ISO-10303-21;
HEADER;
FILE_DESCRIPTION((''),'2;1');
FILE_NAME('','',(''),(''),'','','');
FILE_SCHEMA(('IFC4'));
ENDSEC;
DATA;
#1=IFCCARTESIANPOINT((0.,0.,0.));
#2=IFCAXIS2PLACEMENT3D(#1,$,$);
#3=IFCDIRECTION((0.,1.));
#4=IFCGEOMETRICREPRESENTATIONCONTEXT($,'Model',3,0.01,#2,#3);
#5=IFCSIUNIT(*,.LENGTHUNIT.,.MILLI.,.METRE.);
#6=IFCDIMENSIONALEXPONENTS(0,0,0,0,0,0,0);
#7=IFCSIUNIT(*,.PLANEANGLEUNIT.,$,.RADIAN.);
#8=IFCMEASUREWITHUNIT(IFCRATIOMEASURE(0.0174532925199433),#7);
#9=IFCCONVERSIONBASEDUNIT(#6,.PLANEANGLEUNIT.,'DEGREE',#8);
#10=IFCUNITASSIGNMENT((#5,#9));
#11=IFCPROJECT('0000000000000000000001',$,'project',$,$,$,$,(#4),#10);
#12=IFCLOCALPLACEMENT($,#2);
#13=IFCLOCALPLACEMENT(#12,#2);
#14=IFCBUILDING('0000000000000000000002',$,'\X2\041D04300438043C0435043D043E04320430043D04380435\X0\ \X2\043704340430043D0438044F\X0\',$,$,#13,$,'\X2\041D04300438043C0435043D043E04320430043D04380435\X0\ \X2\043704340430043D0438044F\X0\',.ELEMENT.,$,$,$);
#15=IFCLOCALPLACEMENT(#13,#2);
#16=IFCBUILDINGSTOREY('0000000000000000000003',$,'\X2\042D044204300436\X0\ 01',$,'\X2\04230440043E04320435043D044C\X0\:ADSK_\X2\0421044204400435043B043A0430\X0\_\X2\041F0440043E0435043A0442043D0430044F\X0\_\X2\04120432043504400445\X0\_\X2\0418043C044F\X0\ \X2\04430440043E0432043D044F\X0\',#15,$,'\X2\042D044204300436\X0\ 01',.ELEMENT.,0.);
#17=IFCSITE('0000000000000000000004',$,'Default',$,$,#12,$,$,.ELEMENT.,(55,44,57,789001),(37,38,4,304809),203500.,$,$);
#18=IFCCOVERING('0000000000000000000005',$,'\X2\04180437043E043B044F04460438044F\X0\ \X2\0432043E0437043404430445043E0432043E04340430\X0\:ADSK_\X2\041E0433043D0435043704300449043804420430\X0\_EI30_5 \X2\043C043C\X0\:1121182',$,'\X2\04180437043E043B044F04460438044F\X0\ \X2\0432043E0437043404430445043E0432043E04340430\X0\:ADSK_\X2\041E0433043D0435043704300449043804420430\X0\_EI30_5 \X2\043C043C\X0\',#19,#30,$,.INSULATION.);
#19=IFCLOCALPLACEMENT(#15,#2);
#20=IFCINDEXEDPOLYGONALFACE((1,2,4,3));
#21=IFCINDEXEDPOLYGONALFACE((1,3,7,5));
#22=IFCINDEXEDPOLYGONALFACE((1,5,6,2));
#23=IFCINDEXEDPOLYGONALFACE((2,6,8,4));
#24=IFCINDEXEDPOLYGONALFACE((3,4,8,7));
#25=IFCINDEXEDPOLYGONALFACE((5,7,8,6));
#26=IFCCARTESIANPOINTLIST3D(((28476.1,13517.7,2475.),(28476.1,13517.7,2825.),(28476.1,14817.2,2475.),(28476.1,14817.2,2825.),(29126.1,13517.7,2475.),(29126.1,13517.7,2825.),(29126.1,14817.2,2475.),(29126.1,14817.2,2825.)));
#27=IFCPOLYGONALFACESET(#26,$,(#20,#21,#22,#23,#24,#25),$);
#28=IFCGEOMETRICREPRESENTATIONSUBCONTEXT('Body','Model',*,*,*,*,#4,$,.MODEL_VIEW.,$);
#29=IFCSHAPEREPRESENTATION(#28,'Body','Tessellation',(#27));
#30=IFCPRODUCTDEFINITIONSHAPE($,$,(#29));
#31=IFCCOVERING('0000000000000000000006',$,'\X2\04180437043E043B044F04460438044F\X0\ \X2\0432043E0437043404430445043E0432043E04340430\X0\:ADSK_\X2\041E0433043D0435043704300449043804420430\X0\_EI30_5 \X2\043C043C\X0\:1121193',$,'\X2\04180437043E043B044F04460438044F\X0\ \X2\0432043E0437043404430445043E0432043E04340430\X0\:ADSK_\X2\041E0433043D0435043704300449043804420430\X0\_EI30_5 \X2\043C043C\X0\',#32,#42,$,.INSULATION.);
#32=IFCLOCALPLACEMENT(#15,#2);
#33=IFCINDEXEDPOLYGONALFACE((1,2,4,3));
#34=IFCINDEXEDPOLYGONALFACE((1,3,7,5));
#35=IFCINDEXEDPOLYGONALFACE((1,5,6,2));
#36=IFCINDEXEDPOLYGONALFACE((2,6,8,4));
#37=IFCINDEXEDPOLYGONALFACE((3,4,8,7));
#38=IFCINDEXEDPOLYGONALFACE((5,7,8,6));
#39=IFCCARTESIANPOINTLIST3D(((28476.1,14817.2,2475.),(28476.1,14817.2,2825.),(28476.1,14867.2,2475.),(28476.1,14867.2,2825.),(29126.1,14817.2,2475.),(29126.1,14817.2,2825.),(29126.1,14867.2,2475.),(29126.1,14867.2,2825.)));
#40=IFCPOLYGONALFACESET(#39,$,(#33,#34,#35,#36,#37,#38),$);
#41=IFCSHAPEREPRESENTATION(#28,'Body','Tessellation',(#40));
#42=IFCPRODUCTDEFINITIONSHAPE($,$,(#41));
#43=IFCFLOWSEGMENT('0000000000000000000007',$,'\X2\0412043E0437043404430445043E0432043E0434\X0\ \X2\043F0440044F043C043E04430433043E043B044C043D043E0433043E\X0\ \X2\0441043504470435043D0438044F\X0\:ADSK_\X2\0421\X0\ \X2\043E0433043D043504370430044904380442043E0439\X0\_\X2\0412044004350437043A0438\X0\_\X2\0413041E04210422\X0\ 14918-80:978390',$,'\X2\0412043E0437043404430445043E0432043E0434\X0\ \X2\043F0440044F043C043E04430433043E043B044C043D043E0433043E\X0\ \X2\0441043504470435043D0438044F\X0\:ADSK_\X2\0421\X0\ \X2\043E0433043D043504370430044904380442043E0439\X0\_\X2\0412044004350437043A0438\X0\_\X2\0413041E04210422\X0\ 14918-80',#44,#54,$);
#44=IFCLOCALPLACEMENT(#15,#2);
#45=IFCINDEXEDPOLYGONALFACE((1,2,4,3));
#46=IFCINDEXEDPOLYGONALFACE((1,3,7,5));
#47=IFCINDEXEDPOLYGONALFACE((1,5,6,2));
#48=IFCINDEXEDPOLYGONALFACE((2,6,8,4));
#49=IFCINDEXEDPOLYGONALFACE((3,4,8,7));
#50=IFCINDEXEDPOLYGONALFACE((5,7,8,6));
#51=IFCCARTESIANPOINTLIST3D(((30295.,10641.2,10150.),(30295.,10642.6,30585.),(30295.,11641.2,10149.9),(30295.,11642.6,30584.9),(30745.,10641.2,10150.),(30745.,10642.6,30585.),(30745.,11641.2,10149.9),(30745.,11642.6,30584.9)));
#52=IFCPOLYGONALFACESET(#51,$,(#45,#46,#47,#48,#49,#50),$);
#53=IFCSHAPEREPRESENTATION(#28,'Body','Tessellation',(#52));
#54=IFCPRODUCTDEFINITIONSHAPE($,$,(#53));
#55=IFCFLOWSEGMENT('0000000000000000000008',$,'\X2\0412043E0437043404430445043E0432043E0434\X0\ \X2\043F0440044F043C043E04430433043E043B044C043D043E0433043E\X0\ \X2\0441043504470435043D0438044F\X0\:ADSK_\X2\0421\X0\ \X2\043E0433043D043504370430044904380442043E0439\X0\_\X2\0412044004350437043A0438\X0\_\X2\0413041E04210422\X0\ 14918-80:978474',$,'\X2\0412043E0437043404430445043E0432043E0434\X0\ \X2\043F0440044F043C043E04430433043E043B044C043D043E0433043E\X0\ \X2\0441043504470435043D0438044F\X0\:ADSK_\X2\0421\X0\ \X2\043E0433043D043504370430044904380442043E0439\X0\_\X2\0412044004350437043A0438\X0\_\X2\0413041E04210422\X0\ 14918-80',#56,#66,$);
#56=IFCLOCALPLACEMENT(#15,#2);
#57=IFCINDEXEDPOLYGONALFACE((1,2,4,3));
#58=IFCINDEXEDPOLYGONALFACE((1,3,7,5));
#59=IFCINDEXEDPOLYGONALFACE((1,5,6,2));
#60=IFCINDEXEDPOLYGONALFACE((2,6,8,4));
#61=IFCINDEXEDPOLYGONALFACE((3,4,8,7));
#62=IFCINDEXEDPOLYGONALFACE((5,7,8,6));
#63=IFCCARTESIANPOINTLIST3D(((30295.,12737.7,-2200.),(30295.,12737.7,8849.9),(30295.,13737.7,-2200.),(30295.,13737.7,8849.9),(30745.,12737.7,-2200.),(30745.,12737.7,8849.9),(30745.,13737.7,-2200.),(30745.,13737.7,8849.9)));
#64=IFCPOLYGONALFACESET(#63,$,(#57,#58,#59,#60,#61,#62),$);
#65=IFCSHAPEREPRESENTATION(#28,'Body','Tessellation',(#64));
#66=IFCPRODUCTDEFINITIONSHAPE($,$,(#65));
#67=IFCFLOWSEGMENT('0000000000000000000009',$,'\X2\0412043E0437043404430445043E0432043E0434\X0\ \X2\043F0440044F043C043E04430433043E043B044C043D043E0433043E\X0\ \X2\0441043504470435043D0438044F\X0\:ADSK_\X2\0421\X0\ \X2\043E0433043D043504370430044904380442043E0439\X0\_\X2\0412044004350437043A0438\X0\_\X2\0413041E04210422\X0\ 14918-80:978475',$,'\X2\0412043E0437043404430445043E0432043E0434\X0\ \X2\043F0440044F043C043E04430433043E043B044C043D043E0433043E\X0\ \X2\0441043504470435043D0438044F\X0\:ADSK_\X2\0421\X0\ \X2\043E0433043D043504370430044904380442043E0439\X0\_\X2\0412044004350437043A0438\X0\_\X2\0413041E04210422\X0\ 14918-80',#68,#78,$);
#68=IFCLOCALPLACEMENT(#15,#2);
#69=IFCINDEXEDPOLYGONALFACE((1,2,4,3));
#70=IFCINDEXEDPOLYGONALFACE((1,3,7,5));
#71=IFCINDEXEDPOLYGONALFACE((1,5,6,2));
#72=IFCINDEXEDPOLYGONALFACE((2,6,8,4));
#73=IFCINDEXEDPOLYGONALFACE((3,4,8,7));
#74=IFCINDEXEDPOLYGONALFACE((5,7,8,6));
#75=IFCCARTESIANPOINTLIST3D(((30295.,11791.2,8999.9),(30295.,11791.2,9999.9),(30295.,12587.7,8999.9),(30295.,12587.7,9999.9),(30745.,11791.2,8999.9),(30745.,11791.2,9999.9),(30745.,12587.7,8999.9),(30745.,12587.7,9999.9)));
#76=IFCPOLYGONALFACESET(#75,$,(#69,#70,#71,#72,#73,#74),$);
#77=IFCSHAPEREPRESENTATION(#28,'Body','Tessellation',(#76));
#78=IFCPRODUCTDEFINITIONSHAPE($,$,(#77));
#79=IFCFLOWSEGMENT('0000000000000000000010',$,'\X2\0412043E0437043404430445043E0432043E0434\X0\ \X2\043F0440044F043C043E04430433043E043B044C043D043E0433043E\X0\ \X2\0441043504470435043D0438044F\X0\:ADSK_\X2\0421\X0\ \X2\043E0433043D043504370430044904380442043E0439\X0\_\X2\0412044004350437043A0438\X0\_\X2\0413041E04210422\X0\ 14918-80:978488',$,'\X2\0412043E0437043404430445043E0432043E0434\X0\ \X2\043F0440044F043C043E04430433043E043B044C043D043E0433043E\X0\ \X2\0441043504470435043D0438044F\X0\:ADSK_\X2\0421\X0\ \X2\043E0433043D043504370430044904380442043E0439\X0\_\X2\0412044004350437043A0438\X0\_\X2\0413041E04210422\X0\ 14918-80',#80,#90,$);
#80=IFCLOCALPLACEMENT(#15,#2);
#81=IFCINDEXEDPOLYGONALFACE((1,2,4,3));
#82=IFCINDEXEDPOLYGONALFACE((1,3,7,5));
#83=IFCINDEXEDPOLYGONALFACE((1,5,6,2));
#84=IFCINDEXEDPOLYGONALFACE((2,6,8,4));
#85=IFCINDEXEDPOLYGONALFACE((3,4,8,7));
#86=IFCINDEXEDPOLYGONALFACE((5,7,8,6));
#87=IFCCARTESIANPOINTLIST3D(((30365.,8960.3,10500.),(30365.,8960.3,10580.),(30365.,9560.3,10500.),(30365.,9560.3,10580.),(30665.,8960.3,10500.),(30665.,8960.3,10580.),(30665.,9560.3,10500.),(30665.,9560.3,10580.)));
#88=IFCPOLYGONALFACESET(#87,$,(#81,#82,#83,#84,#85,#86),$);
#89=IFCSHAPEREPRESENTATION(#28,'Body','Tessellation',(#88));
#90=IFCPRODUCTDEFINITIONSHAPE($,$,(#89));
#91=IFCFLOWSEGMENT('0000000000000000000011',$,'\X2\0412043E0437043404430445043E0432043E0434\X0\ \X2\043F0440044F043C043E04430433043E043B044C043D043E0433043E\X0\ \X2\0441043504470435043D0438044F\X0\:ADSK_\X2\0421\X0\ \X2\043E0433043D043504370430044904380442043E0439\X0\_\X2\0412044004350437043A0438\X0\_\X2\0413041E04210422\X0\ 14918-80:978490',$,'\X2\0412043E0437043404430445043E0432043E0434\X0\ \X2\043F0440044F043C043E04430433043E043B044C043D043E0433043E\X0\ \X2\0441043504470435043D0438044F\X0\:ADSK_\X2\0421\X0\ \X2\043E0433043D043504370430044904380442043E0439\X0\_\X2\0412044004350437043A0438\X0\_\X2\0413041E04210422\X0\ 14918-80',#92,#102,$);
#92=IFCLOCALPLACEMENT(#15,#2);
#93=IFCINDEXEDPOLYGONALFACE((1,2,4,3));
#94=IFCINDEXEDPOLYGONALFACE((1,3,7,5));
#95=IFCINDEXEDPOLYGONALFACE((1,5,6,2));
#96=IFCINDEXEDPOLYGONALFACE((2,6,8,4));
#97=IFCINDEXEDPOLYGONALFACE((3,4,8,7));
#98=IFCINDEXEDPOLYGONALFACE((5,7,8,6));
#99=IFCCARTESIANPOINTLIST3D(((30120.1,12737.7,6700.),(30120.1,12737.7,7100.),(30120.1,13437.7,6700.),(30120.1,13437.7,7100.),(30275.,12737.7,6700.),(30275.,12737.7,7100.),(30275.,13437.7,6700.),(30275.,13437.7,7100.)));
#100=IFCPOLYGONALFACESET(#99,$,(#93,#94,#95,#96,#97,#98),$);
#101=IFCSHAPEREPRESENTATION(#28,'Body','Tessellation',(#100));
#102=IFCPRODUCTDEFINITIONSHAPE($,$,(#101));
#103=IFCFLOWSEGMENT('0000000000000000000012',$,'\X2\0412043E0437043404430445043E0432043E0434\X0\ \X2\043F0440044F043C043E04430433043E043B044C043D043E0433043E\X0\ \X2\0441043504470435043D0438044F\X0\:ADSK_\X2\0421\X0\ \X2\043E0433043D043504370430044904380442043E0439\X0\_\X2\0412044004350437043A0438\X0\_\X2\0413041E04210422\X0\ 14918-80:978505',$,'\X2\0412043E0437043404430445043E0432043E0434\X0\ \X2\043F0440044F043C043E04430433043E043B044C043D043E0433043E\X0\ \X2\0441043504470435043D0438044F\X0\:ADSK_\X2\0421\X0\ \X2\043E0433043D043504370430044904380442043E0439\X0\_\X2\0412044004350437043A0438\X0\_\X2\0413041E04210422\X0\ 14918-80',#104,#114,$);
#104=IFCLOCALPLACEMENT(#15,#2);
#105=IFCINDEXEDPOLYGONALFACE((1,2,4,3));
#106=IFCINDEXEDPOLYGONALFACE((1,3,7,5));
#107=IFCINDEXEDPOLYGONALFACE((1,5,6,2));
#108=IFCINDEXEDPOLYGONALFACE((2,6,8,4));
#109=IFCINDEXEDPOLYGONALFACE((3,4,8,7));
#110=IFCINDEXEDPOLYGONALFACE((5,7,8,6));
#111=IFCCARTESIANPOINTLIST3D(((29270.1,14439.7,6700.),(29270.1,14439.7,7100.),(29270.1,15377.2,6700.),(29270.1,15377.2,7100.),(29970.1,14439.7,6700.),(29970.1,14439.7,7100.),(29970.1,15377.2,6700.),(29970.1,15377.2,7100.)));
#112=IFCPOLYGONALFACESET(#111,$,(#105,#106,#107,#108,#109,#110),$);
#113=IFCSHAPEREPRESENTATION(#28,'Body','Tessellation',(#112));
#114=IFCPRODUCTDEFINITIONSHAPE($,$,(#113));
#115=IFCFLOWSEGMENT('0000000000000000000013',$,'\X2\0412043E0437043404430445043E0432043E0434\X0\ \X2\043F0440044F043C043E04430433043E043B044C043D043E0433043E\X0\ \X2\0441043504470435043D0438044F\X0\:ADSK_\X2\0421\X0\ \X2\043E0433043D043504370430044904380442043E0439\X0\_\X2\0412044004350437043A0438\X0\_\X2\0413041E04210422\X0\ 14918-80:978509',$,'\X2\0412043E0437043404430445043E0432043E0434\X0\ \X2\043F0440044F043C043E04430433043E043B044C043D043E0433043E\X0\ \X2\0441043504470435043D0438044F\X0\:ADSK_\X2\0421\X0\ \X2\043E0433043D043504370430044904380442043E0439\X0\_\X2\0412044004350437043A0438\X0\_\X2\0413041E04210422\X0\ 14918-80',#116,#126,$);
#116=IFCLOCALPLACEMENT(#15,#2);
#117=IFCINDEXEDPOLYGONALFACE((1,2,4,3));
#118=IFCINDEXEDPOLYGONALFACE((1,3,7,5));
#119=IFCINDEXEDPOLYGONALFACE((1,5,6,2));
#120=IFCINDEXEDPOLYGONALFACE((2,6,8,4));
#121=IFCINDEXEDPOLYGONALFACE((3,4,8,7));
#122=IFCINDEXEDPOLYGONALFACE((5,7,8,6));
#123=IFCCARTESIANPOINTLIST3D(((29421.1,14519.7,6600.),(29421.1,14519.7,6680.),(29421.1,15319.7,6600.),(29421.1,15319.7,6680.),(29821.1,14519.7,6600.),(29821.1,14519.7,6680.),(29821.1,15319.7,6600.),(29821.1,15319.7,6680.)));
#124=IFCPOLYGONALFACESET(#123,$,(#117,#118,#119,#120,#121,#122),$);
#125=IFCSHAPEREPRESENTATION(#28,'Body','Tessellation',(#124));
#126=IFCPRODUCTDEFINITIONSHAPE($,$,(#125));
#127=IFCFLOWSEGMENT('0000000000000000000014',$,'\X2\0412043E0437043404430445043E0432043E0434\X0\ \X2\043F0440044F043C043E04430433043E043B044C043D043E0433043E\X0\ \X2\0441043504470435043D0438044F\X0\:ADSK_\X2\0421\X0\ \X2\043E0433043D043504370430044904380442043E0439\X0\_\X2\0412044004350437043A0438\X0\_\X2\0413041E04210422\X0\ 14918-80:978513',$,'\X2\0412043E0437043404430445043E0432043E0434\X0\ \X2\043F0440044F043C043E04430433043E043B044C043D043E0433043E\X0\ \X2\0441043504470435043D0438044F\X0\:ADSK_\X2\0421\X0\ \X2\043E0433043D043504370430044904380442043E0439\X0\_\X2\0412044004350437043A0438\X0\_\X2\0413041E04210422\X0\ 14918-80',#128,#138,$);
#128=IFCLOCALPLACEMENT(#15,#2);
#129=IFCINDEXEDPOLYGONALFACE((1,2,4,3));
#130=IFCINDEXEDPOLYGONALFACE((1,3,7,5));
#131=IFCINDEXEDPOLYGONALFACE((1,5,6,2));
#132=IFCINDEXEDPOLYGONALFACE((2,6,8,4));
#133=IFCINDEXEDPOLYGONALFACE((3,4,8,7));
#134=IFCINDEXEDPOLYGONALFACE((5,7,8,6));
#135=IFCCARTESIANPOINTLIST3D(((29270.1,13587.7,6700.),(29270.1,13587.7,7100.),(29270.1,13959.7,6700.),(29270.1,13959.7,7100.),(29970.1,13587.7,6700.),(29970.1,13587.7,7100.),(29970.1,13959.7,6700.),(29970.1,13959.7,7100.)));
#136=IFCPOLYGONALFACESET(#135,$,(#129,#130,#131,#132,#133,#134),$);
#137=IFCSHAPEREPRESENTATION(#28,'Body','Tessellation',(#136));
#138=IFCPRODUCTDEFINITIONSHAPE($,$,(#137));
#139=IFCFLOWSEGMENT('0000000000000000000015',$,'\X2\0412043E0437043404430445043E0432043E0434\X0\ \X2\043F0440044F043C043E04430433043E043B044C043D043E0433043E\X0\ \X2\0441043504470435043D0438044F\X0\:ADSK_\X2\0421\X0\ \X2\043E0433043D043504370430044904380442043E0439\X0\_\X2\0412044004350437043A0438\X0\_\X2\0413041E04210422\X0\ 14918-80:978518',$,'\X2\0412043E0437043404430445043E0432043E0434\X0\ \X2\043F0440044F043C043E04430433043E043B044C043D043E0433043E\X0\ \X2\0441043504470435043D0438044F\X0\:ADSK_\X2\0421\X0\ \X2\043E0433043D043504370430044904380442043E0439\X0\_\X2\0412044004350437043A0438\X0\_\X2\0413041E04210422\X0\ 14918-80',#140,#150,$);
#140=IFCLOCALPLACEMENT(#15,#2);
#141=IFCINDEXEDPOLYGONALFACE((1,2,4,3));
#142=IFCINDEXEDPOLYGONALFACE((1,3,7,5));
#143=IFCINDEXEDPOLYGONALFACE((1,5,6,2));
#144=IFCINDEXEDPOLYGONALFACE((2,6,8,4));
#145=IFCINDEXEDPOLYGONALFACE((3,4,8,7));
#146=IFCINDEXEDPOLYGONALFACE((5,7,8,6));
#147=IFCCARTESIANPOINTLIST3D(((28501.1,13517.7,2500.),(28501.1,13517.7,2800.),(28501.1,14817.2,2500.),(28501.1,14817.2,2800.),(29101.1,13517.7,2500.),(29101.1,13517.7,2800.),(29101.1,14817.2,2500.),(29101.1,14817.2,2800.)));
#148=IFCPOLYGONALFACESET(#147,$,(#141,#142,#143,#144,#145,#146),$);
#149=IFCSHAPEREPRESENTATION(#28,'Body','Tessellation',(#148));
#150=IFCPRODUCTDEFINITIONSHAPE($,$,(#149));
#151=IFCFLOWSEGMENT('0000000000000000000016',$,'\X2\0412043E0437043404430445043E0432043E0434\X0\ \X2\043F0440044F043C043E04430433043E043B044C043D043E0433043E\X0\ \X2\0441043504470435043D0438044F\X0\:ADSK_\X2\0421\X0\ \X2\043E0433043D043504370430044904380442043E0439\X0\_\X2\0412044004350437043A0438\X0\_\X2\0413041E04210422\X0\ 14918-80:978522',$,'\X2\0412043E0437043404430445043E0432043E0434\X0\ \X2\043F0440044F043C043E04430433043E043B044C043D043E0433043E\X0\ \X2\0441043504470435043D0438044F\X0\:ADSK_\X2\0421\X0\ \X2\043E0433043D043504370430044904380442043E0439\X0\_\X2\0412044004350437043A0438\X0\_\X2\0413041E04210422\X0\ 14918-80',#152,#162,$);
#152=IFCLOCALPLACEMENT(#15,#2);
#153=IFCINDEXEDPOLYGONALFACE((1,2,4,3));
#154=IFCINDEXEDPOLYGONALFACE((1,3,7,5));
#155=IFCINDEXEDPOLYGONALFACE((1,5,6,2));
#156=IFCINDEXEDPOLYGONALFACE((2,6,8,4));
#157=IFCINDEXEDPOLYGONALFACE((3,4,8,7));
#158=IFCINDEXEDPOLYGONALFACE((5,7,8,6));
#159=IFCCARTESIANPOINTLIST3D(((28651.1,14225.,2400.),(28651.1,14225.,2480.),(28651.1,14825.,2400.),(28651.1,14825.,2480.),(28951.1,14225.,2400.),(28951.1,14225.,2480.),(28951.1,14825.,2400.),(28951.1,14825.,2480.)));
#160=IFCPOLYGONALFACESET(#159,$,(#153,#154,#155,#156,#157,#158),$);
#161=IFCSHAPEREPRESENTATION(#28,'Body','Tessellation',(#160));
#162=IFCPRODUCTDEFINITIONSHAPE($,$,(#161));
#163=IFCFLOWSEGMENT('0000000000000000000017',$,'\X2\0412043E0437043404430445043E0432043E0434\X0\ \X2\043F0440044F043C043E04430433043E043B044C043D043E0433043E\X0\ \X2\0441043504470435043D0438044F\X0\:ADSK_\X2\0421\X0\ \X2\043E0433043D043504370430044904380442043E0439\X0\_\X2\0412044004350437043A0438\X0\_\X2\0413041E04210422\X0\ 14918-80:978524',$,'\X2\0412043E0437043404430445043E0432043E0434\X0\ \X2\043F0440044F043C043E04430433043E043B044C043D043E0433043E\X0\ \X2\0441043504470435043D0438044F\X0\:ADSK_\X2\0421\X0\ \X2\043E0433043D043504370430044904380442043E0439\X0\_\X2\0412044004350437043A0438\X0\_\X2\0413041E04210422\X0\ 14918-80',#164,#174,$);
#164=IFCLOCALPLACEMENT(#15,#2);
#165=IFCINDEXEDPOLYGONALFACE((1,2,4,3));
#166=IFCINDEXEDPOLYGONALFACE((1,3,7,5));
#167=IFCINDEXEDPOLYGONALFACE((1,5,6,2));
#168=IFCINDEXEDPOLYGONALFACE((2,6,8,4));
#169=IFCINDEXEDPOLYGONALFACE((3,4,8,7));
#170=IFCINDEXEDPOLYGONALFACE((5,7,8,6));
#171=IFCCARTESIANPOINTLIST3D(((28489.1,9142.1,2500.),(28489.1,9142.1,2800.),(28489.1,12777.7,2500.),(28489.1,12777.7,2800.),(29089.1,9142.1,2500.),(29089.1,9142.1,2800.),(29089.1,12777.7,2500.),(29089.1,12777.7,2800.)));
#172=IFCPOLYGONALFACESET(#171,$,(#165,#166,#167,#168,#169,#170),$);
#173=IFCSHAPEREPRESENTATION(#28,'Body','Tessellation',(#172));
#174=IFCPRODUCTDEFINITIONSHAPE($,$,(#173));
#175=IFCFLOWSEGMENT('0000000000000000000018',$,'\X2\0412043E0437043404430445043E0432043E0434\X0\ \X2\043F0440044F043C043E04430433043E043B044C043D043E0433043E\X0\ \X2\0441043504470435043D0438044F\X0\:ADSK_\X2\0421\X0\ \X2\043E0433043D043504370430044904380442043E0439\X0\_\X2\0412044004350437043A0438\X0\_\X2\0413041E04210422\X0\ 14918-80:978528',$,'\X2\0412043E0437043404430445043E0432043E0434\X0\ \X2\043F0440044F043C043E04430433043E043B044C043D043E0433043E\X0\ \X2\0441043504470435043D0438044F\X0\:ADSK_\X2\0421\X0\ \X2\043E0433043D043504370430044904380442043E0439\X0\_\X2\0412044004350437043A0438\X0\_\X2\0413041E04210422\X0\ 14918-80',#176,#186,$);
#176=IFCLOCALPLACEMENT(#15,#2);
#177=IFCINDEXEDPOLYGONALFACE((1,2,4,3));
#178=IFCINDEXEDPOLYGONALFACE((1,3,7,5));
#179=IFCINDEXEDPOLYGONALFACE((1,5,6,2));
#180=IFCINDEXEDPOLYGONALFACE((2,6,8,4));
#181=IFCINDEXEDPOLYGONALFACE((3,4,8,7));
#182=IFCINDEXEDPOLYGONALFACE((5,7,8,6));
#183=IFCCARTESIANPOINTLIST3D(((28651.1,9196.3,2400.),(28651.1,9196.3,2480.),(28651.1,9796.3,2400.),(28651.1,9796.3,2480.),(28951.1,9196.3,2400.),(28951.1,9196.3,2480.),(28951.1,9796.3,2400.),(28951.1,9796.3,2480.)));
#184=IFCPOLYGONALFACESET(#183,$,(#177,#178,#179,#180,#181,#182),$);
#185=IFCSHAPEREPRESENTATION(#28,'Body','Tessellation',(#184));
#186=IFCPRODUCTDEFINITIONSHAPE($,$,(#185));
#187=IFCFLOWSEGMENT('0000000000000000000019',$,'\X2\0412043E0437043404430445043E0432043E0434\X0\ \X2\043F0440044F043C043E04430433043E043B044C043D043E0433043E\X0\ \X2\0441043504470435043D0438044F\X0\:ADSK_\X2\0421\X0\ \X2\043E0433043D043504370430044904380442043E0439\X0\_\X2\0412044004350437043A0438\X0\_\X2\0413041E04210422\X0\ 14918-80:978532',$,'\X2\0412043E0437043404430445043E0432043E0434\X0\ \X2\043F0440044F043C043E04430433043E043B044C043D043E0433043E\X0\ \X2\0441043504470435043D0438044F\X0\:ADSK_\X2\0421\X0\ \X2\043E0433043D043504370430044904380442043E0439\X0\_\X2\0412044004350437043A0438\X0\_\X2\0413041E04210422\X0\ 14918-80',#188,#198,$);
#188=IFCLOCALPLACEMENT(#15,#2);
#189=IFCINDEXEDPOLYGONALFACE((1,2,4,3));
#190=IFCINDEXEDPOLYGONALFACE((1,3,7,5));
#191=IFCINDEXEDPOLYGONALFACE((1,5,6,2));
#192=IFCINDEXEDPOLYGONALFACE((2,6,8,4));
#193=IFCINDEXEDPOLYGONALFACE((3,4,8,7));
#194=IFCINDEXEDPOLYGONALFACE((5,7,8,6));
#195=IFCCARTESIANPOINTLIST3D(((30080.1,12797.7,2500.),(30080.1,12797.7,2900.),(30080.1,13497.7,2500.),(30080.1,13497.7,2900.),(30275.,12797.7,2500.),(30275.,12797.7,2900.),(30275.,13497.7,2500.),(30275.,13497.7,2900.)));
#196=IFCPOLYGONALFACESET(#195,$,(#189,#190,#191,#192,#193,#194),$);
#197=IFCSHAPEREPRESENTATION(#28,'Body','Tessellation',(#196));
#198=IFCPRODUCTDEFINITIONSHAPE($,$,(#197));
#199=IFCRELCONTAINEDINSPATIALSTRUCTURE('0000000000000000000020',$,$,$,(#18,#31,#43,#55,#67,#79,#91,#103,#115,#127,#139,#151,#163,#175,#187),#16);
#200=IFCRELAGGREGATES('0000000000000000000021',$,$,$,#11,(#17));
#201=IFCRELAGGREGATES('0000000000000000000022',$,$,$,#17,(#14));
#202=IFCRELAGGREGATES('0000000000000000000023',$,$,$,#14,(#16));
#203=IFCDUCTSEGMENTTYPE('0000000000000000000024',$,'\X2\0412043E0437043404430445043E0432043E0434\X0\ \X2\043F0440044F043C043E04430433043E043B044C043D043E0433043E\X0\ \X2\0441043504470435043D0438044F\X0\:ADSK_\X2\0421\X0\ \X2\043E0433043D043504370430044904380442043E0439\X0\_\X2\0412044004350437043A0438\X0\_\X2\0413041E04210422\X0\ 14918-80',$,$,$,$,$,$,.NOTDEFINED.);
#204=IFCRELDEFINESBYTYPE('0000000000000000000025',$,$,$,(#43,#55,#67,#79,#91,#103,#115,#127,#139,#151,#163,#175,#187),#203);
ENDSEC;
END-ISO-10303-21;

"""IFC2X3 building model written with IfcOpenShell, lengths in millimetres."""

from ifc_helpers import new_model, entity, si_unit, converted_unit, direction, frame, frame_2d, origin, origin_2d_with_axis, place, context, subcontext, project, spatial, rectangle, extrude, type_object, element, save


model = new_model("IFC2X3")

# Units and contexts
model_context = context("Model", 3, precision=0.01, world=origin(), true_north=direction((0.0, 1.0)))
body_context = subcontext(model_context, "Body", "Model", "MODEL_VIEW")
ifc_project = project(units=[si_unit("LENGTHUNIT", "METRE", prefix="MILLI"), converted_unit("PLANEANGLEUNIT", "DEGREE", entity("IfcRatioMeasure", 0.0174532925199433), si_unit("PLANEANGLEUNIT", "RADIAN"), dimensions=[0, 0, 0, 0, 0, 0, 0])], contexts=[model_context])

# Site, building, storey
site_placement = place(None, frame((0.0, 0.0, 0.0)))
site = spatial("IfcSite", under=ifc_project, at=site_placement, Name="Default", CompositionType="ELEMENT", RefLatitude=(55, 44, 57, 789001), RefLongitude=(37, 38, 4, 304809), RefElevation=203500.0)
building_placement = place(site_placement, origin())
building = spatial("IfcBuilding", under=site, at=building_placement, Name="Наименование здания", LongName="Наименование здания", CompositionType="ELEMENT")
storey_placement = place(building_placement, origin())
storey = spatial("IfcBuildingStorey", under=building, at=storey_placement, Name="Этаж 01", ObjectType="Уровень:ADSK_Стрелка_Проектная_Вверх_Имя уровня", LongName="Этаж 01", CompositionType="ELEMENT", Elevation=0.0)

# Coverings
covering_1_placement = place(storey_placement, frame((28476.1, 13517.7, 2475.0)))
element("IfcCovering", 1, at=covering_1_placement, inside=storey, Name="Изоляция воздуховода:ADSK_Огнезащита_EI30_5 мм:1121182", ObjectType="Изоляция воздуховода:ADSK_Огнезащита_EI30_5 мм", PredefinedType="INSULATION", context=body_context, shape_type="SweptSolid", body=[
    extrude(rectangle(XDim=1299.5, YDim=650.0, at=frame_2d((0.0, 0.0), x_axis=(1.0, 0.0))), frame((325.0, 649.8, 0.0), z_axis=(0.0, 0.0, 1.0), x_axis=(0.0, 1.0, 0.0)), (0.0, 0.0, 1.0), 350.0),
])
covering_2_placement = place(storey_placement, frame((28476.1, 14817.2, 2475.0)))
element("IfcCovering", 2, at=covering_2_placement, inside=storey, Name="Изоляция воздуховода:ADSK_Огнезащита_EI30_5 мм:1121193", ObjectType="Изоляция воздуховода:ADSK_Огнезащита_EI30_5 мм", PredefinedType="INSULATION", context=body_context, shape_type="SweptSolid", body=[
    extrude(rectangle(XDim=50.0, YDim=650.0, at=frame_2d((0.0, 0.0), x_axis=(1.0, 0.0))), frame((325.0, 25.0, 0.0), z_axis=(0.0, 0.0, 1.0), x_axis=(0.0, -1.0, 0.0)), (0.0, 0.0, 1.0), 350.0),
])

# Flow segments
duct_segment_type = type_object("IfcDuctSegmentType", Name="Воздуховод прямоугольного сечения:ADSK_С огнезащитой_Врезки_ГОСТ 14918-80", PredefinedType="NOTDEFINED")
flow_segment_1_placement = place(storey_placement, frame((30295.0, 10641.2, 10149.9)))
element("IfcFlowSegment", 3, at=flow_segment_1_placement, inside=storey, type_object=duct_segment_type, Name="Воздуховод прямоугольного сечения:ADSK_С огнезащитой_Врезки_ГОСТ 14918-80:978390", ObjectType="Воздуховод прямоугольного сечения:ADSK_С огнезащитой_Врезки_ГОСТ 14918-80", context=body_context, shape_type="SweptSolid", body=[
    extrude(rectangle(XDim=1000.0, YDim=450.0, at=frame_2d((0.0, 0.0), x_axis=(0.0, 1.0))), frame((225.0, 500.0, 0.0), z_axis=(0.0, 0.000067, 1.0), x_axis=(1.0, 0.0, 0.0)), (0.0, 0.0, 1.0), 20435.0),
])
flow_segment_2_placement = place(storey_placement, frame((30295.0, 12737.7, -2200.0)))
element("IfcFlowSegment", 4, at=flow_segment_2_placement, inside=storey, type_object=duct_segment_type, Name="Воздуховод прямоугольного сечения:ADSK_С огнезащитой_Врезки_ГОСТ 14918-80:978474", ObjectType="Воздуховод прямоугольного сечения:ADSK_С огнезащитой_Врезки_ГОСТ 14918-80", context=body_context, shape_type="SweptSolid", body=[
    extrude(rectangle(XDim=1000.0, YDim=450.0, at=origin_2d_with_axis()), frame((225.0, 500.0, 0.0), z_axis=(0.0, 0.0, 1.0), x_axis=(0.0, 1.0, 0.0)), (0.0, 0.0, 1.0), 11049.9),
])
flow_segment_3_placement = place(storey_placement, frame((30295.0, 11791.2, 8999.9)))
element("IfcFlowSegment", 5, at=flow_segment_3_placement, inside=storey, type_object=duct_segment_type, Name="Воздуховод прямоугольного сечения:ADSK_С огнезащитой_Врезки_ГОСТ 14918-80:978475", ObjectType="Воздуховод прямоугольного сечения:ADSK_С огнезащитой_Врезки_ГОСТ 14918-80", context=body_context, shape_type="SweptSolid", body=[
    extrude(rectangle(XDim=796.6, YDim=450.0, at=origin_2d_with_axis()), frame((225.0, 398.3, 0.0), z_axis=(0.0, 0.0, 1.0), x_axis=(0.0, -1.0, 0.0)), (0.0, 0.0, 1.0), 1000.0),
])
flow_segment_4_placement = place(storey_placement, frame((30365.0, 8960.3, 10500.0)))
element("IfcFlowSegment", 6, at=flow_segment_4_placement, inside=storey, type_object=duct_segment_type, Name="Воздуховод прямоугольного сечения:ADSK_С огнезащитой_Врезки_ГОСТ 14918-80:978488", ObjectType="Воздуховод прямоугольного сечения:ADSK_С огнезащитой_Врезки_ГОСТ 14918-80", context=body_context, shape_type="SweptSolid", body=[
    extrude(rectangle(XDim=300.0, YDim=600.0, at=origin_2d_with_axis()), frame((150.0, 300.0, 0.0)), (0.0, 0.0, 1.0), 80.0),
])
flow_segment_5_placement = place(storey_placement, frame((30120.1, 12737.7, 6700.0)))
element("IfcFlowSegment", 7, at=flow_segment_5_placement, inside=storey, type_object=duct_segment_type, Name="Воздуховод прямоугольного сечения:ADSK_С огнезащитой_Врезки_ГОСТ 14918-80:978490", ObjectType="Воздуховод прямоугольного сечения:ADSK_С огнезащитой_Врезки_ГОСТ 14918-80", context=body_context, shape_type="SweptSolid", body=[
    extrude(rectangle(XDim=155.0, YDim=700.0, at=frame_2d((0.0, 0.0), x_axis=(1.0, 0.0))), frame((77.5, 350.0, 0.0), z_axis=(0.0, 0.0, 1.0), x_axis=(-1.0, 0.0, 0.0)), (0.0, 0.0, 1.0), 400.0),
])
flow_segment_6_placement = place(storey_placement, frame((29270.1, 14439.7, 6700.0)))
element("IfcFlowSegment", 8, at=flow_segment_6_placement, inside=storey, type_object=duct_segment_type, Name="Воздуховод прямоугольного сечения:ADSK_С огнезащитой_Врезки_ГОСТ 14918-80:978505", ObjectType="Воздуховод прямоугольного сечения:ADSK_С огнезащитой_Врезки_ГОСТ 14918-80", context=body_context, shape_type="SweptSolid", body=[
    extrude(rectangle(XDim=937.5, YDim=700.0, at=frame_2d((0.0, 0.0), x_axis=(1.0, 0.0))), frame((350.0, 468.8, 0.0), z_axis=(0.0, 0.0, 1.0), x_axis=(0.0, -1.0, 0.0)), (0.0, 0.0, 1.0), 400.0),
])
flow_segment_7_placement = place(storey_placement, frame((29421.1, 14519.7, 6600.0)))
element("IfcFlowSegment", 9, at=flow_segment_7_placement, inside=storey, type_object=duct_segment_type, Name="Воздуховод прямоугольного сечения:ADSK_С огнезащитой_Врезки_ГОСТ 14918-80:978509", ObjectType="Воздуховод прямоугольного сечения:ADSK_С огнезащитой_Врезки_ГОСТ 14918-80", context=body_context, shape_type="SweptSolid", body=[
    extrude(rectangle(XDim=800.0, YDim=400.0, at=frame_2d((0.0, 0.0), x_axis=(1.0, 0.0))), frame((200.0, 400.0, 0.0), z_axis=(0.0, 0.0, 1.0), x_axis=(0.0, 1.0, 0.0)), (0.0, 0.0, 1.0), 80.0),
])
flow_segment_8_placement = place(storey_placement, frame((29270.1, 13587.7, 6700.0)))
element("IfcFlowSegment", 10, at=flow_segment_8_placement, inside=storey, type_object=duct_segment_type, Name="Воздуховод прямоугольного сечения:ADSK_С огнезащитой_Врезки_ГОСТ 14918-80:978513", ObjectType="Воздуховод прямоугольного сечения:ADSK_С огнезащитой_Врезки_ГОСТ 14918-80", context=body_context, shape_type="SweptSolid", body=[
    extrude(rectangle(XDim=372.0, YDim=700.0, at=frame_2d((0.0, 0.0), x_axis=(1.0, 0.0))), frame((350.0, 186.0, 0.0), z_axis=(0.0, 0.0, 1.0), x_axis=(0.0, 1.0, 0.0)), (0.0, 0.0, 1.0), 400.0),
])
flow_segment_9_placement = place(storey_placement, frame((28501.1, 13517.7, 2500.0)))
element("IfcFlowSegment", 11, at=flow_segment_9_placement, inside=storey, type_object=duct_segment_type, Name="Воздуховод прямоугольного сечения:ADSK_С огнезащитой_Врезки_ГОСТ 14918-80:978518", ObjectType="Воздуховод прямоугольного сечения:ADSK_С огнезащитой_Врезки_ГОСТ 14918-80", context=body_context, shape_type="SweptSolid", body=[
    extrude(rectangle(XDim=1299.5, YDim=600.0, at=frame_2d((0.0, 0.0), x_axis=(1.0, 0.0))), frame((300.0, 649.8, 0.0), z_axis=(0.0, 0.0, 1.0), x_axis=(0.0, 1.0, 0.0)), (0.0, 0.0, 1.0), 300.0),
])
flow_segment_10_placement = place(storey_placement, frame((28651.1, 14225.0, 2400.0)))
element("IfcFlowSegment", 12, at=flow_segment_10_placement, inside=storey, type_object=duct_segment_type, Name="Воздуховод прямоугольного сечения:ADSK_С огнезащитой_Врезки_ГОСТ 14918-80:978522", ObjectType="Воздуховод прямоугольного сечения:ADSK_С огнезащитой_Врезки_ГОСТ 14918-80", context=body_context, shape_type="SweptSolid", body=[
    extrude(rectangle(XDim=600.0, YDim=300.0, at=frame_2d((0.0, 0.0), x_axis=(1.0, 0.0))), frame((150.0, 300.0, 0.0), z_axis=(0.0, 0.0, 1.0), x_axis=(0.0, 1.0, 0.0)), (0.0, 0.0, 1.0), 80.0),
])
flow_segment_11_placement = place(storey_placement, frame((28489.1, 9142.1, 2500.0)))
element("IfcFlowSegment", 13, at=flow_segment_11_placement, inside=storey, type_object=duct_segment_type, Name="Воздуховод прямоугольного сечения:ADSK_С огнезащитой_Врезки_ГОСТ 14918-80:978524", ObjectType="Воздуховод прямоугольного сечения:ADSK_С огнезащитой_Врезки_ГОСТ 14918-80", context=body_context, shape_type="SweptSolid", body=[
    extrude(rectangle(XDim=3635.6, YDim=600.0, at=frame_2d((0.0, 0.0), x_axis=(1.0, 0.0))), frame((300.0, 1817.8, 0.0), z_axis=(0.0, 0.0, 1.0), x_axis=(0.0, -1.0, 0.0)), (0.0, 0.0, 1.0), 300.0),
])
flow_segment_12_placement = place(storey_placement, frame((28651.1, 9196.3, 2400.0)))
element("IfcFlowSegment", 14, at=flow_segment_12_placement, inside=storey, type_object=duct_segment_type, Name="Воздуховод прямоугольного сечения:ADSK_С огнезащитой_Врезки_ГОСТ 14918-80:978528", ObjectType="Воздуховод прямоугольного сечения:ADSK_С огнезащитой_Врезки_ГОСТ 14918-80", context=body_context, shape_type="SweptSolid", body=[
    extrude(rectangle(XDim=600.0, YDim=300.0, at=origin_2d_with_axis()), frame((150.0, 300.0, 0.0), z_axis=(0.0, 0.0, 1.0), x_axis=(0.0, 1.0, 0.0)), (0.0, 0.0, 1.0), 80.0),
])
flow_segment_13_placement = place(storey_placement, frame((30080.1, 12797.7, 2500.0)))
element("IfcFlowSegment", 15, at=flow_segment_13_placement, inside=storey, type_object=duct_segment_type, Name="Воздуховод прямоугольного сечения:ADSK_С огнезащитой_Врезки_ГОСТ 14918-80:978532", ObjectType="Воздуховод прямоугольного сечения:ADSK_С огнезащитой_Врезки_ГОСТ 14918-80", context=body_context, shape_type="SweptSolid", body=[
    extrude(rectangle(XDim=194.9, YDim=700.0, at=frame_2d((0.0, 0.0), x_axis=(1.0, 0.0))), frame((97.4, 350.0, 0.0), z_axis=(0.0, 0.0, 1.0), x_axis=(-1.0, 0.0, 0.0)), (0.0, 0.0, 1.0), 400.0),
])

save(model, "model.ifc")
